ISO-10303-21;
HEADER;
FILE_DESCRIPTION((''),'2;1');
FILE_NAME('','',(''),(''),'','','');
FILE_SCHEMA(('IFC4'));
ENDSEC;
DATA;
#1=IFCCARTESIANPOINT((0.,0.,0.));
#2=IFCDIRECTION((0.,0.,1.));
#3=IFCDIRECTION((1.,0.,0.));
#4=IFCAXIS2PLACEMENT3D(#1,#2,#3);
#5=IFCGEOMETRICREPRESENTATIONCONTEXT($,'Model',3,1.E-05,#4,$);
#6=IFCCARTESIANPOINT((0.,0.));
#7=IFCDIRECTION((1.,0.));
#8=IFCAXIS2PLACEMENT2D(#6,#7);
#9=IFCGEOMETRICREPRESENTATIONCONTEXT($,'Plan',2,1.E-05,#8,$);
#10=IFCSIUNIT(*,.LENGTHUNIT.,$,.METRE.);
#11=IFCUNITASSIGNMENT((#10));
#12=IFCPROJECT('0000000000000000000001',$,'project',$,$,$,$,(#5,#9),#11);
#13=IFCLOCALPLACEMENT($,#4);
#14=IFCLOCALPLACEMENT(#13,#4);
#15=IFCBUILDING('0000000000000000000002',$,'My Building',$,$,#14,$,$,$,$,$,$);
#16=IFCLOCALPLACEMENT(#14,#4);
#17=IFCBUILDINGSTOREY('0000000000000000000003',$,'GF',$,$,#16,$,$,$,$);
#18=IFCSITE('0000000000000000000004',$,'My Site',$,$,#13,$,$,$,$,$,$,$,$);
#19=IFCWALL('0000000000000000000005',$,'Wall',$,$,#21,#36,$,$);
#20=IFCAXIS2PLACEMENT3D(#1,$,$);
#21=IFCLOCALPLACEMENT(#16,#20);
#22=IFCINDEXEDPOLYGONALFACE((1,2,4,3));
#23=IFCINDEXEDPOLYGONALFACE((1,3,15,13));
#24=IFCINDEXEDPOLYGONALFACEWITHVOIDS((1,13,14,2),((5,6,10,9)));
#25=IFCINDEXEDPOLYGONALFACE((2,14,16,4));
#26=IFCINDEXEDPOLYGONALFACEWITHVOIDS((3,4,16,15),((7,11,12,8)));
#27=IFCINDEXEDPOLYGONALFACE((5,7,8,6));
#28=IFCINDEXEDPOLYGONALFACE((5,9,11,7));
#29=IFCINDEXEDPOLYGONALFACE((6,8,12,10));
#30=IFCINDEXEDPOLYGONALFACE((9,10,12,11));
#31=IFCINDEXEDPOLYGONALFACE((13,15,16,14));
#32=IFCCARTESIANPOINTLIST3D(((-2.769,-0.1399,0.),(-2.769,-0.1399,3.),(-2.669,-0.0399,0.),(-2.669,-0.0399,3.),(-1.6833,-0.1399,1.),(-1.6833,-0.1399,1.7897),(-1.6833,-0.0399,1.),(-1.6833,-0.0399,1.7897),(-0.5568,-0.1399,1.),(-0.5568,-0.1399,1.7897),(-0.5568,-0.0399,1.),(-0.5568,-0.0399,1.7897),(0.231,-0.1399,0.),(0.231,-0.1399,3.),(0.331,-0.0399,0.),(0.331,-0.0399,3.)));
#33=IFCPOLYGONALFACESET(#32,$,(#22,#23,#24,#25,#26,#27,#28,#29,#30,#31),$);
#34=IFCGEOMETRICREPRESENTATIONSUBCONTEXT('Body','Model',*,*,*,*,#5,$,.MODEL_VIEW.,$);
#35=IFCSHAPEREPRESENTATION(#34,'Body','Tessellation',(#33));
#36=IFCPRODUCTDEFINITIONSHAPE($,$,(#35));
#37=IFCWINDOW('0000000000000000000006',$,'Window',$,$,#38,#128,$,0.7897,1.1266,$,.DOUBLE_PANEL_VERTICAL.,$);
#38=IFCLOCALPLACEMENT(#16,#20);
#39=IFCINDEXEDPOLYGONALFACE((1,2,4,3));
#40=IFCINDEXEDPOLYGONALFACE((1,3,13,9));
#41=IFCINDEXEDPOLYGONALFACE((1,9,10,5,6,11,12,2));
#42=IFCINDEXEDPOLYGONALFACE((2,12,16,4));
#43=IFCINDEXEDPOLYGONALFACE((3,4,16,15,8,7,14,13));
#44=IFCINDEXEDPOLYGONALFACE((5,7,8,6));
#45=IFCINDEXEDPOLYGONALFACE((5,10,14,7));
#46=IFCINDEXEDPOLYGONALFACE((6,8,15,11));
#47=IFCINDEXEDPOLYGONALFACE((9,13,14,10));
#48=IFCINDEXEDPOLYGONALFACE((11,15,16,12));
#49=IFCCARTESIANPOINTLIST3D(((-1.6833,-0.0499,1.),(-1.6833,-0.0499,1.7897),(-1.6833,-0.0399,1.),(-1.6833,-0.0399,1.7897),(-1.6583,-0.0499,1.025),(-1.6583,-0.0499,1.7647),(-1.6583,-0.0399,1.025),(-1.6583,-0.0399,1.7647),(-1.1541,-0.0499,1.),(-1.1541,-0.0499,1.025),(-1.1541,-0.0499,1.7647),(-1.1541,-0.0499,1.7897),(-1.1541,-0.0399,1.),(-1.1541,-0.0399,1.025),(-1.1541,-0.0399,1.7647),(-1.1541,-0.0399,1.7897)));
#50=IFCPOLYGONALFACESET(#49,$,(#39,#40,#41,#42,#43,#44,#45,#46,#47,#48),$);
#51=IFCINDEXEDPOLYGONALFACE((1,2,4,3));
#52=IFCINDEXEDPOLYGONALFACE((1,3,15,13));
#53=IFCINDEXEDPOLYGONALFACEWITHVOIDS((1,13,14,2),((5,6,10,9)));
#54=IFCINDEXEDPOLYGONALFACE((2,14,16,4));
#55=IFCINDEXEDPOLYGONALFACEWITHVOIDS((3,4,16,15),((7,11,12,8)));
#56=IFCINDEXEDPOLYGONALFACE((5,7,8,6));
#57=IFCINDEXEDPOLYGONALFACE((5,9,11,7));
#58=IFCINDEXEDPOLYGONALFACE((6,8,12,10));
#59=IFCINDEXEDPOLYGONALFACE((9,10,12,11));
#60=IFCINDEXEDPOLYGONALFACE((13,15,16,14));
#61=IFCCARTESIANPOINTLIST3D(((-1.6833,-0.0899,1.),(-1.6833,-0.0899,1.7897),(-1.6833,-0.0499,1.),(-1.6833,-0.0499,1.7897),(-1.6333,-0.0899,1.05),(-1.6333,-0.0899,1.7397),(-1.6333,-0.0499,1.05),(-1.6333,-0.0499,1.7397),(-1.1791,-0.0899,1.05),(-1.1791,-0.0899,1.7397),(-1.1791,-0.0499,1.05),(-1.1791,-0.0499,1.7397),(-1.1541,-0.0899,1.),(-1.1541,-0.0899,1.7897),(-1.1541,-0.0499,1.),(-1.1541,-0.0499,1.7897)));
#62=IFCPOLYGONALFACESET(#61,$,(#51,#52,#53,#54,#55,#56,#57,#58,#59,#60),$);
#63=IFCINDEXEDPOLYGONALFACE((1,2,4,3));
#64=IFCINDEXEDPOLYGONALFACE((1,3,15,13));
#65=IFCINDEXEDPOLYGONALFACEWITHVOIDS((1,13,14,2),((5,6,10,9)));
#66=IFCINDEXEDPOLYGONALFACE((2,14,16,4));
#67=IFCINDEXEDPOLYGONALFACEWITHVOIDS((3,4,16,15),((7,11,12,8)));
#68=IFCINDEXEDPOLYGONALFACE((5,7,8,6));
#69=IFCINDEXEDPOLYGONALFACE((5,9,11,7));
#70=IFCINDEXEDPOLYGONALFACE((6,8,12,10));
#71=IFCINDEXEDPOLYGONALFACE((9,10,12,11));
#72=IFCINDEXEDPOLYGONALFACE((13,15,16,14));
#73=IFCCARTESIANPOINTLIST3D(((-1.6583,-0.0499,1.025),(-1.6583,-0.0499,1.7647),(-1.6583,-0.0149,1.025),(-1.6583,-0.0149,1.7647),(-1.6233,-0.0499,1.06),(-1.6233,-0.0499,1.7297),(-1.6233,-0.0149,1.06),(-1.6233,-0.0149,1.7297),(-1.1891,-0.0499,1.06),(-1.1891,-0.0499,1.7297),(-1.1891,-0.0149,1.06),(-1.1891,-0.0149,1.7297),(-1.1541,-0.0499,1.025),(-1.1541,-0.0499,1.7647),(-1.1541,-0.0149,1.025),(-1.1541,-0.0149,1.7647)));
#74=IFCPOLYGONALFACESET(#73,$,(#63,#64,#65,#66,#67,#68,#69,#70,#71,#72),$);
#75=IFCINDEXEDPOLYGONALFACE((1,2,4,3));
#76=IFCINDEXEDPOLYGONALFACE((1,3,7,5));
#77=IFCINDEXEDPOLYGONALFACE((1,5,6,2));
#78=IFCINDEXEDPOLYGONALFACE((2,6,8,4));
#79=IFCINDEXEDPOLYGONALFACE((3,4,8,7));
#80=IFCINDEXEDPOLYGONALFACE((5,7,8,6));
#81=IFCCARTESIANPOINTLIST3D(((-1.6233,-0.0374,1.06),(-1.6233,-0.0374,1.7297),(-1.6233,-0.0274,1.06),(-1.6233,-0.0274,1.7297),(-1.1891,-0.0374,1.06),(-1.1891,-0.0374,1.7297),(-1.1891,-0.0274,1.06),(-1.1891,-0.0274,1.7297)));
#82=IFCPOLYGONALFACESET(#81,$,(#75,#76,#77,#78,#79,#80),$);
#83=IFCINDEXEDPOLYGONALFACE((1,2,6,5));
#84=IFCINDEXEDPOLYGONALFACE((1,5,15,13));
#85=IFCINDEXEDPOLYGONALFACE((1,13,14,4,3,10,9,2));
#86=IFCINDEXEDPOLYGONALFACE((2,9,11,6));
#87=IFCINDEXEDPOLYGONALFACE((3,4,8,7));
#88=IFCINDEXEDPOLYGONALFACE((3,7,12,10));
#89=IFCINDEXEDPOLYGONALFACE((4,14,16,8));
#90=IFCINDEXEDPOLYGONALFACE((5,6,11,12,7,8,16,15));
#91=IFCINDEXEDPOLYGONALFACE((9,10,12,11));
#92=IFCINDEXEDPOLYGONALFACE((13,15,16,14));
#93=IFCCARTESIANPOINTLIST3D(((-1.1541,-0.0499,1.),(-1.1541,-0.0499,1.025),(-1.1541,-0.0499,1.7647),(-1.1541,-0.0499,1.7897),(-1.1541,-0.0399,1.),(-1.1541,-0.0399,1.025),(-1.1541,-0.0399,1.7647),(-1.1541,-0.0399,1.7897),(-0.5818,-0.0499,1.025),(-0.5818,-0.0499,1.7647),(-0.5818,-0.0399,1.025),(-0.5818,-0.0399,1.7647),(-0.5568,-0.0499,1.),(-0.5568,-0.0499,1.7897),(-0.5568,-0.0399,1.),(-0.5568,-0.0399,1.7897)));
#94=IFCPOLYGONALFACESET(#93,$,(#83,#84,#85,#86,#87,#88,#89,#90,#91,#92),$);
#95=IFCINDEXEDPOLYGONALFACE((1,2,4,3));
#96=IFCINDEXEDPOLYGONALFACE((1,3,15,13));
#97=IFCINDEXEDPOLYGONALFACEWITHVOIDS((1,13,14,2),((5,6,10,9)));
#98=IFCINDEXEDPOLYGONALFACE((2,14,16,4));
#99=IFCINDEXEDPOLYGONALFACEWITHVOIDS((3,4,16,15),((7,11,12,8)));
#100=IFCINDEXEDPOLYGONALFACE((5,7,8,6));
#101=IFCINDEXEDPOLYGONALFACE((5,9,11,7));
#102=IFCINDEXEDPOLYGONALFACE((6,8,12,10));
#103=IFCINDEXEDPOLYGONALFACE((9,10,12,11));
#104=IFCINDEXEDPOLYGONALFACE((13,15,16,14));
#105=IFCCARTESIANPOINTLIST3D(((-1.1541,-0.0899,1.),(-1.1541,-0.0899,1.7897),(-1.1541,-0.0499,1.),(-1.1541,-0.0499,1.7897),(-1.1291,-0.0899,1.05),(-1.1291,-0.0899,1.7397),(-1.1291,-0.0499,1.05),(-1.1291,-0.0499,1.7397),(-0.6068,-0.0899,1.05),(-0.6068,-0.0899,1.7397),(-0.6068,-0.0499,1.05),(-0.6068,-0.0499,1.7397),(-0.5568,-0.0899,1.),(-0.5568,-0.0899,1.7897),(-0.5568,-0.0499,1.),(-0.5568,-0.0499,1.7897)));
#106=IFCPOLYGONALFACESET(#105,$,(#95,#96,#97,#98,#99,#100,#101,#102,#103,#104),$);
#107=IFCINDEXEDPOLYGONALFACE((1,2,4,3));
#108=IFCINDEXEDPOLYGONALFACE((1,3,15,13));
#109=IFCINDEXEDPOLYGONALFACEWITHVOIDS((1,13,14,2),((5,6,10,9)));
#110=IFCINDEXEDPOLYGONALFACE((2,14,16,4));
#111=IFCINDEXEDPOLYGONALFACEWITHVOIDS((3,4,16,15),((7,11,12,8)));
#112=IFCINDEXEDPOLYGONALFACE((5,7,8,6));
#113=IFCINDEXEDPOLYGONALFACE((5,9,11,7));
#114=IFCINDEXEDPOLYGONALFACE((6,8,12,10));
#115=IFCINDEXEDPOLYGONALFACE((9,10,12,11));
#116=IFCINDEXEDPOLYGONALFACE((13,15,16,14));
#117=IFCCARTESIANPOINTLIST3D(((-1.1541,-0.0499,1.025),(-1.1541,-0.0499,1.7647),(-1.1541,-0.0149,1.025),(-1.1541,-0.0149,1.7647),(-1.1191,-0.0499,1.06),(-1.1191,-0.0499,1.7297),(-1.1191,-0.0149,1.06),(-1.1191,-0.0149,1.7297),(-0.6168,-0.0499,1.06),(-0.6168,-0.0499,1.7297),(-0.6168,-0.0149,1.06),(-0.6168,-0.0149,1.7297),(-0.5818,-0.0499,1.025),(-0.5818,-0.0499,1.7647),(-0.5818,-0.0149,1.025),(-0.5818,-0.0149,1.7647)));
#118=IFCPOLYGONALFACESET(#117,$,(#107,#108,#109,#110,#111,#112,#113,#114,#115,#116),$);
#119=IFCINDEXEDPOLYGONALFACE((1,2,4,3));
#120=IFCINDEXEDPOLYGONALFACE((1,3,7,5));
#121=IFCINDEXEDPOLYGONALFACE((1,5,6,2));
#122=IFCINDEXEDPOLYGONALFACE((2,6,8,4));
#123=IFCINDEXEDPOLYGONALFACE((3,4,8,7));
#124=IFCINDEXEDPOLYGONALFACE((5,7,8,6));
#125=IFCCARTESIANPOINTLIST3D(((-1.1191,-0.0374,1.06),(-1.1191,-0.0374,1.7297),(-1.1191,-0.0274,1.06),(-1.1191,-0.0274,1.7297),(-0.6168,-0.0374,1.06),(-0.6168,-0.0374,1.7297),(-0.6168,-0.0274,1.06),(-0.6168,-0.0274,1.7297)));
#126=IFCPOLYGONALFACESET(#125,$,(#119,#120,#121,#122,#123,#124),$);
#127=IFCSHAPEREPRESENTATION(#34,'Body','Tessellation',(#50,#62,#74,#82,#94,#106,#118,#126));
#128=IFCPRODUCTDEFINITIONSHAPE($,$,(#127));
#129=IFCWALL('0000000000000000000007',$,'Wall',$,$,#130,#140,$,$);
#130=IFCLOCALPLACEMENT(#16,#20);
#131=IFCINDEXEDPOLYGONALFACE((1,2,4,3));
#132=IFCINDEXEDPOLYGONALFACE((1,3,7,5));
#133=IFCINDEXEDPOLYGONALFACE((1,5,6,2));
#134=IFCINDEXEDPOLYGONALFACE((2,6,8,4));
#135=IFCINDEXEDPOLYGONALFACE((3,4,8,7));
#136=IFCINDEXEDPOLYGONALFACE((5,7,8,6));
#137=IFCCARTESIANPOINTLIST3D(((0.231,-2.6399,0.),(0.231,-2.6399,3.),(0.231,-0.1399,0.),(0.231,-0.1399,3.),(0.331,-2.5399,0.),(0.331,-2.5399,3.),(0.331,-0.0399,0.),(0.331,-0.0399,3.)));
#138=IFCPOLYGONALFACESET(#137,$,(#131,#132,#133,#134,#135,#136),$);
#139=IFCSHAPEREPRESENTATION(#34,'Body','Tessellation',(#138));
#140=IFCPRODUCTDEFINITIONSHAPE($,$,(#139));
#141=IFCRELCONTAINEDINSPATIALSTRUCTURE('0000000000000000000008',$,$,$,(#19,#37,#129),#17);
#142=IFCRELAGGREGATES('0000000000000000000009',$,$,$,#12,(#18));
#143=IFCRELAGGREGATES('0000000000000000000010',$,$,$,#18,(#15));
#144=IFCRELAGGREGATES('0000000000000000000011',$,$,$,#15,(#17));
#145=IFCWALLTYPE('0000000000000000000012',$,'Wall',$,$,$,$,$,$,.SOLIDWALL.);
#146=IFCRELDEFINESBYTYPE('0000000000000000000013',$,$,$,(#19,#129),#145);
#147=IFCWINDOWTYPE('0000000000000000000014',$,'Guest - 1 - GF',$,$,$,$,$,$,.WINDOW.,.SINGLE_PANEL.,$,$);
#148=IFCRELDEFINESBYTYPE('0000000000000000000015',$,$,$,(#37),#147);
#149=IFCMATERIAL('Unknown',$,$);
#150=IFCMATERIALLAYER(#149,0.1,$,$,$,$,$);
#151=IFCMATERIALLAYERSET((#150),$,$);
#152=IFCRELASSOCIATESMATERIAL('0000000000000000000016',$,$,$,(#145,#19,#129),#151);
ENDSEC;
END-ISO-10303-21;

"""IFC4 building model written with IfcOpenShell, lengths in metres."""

from ifc_helpers import new_model, entity, si_unit, frame, origin_with_axes, origin_2d_with_axis, place, context, subcontext, project, spatial, line, indexed_curve, outline, extrude, shape, source, transform, mapped, material, layer, layer_set, layer_usage, type_object, type_shapes, element, fill, save


model = new_model("IFC4")

# Units and contexts
model_context = context("Model", 3, precision=1e-05, world=origin_with_axes())
plan_context = context("Plan", 2, precision=1e-05, world=origin_2d_with_axis())
body_context_1 = subcontext(model_context, "Body", "Model", "MODEL_VIEW")
body_context_2 = subcontext(plan_context, "Body", "Plan", "PLAN_VIEW")
ifc_project = project(units=[si_unit("LENGTHUNIT", "METRE")], contexts=[model_context, plan_context])

# Site, building, storey
site_placement = place(None, origin_with_axes())
site = spatial("IfcSite", under=ifc_project, at=site_placement, Name="My Site")
building_placement = place(site_placement, origin_with_axes())
building = spatial("IfcBuilding", under=site, at=building_placement, Name="My Building")
storey_placement = place(building_placement, origin_with_axes())
storey = spatial("IfcBuildingStorey", under=building, at=storey_placement, Name="GF")

# Shared definitions
ifc_material = material(Name="Unknown")

# Shared definitions
ifc_layer_1 = layer(ifc_material, 0.1)
ifc_layer_set_1 = layer_set([ifc_layer_1])
wall_type = type_object("IfcWallType", Name="Wall", PredefinedType="SOLIDWALL", material=ifc_layer_set_1)

# Wall, opening, window
ifc_layer_usage_1 = layer_usage(ifc_layer_set_1, "AXIS2", "POSITIVE", 0.0)
wall_1_placement = place(storey_placement, frame((-2.769, -0.1399, 0.0), z_axis=(0.0, 0.0, 1.0), x_axis=(1.0, 0.0, 0.0)))
wall_1 = element("IfcWall", 1, at=wall_1_placement, inside=storey, type_object=wall_type, material=ifc_layer_usage_1, Name="Wall", context=body_context_1, shape_type="SweptSolid", body=[
    extrude(outline(indexed_curve([(0.0, 0.0), (0.1, 0.1), (3.1, 0.1), (3.0, 0.0)], segments=[line(1, 2, 3, 4, 1)])), origin_with_axes(), (0.0, 0.0, 1.0), 3.0),
])
shared_shape_1 = source(origin_with_axes(), body_context_1, "Body", "SweptSolid", [
    extrude(outline(indexed_curve([(0.0, 0.0), (1.1266, 0.0), (1.1266, 0.7897), (0.0, 0.7897)], segments=[line(1, 2, 3, 4, 1)])), frame((0.0, -0.6, 0.0), z_axis=(0.0, -1.0, 0.0), x_axis=(1.0, 0.0, 0.0)), (0.0, 0.0, -1.0), 1.2),
])
opening_1_placement = place(wall_1_placement, frame((1.0857, 0.0, 1.0), z_axis=(0.0, 0.0, 1.0), x_axis=(1.0, 0.0, 0.0)))
opening_1 = element("IfcOpeningElement", 2, at=opening_1_placement, cuts=wall_1, PredefinedType="OPENING", context=body_context_1, shape_type="MappedRepresentation", body=[
    mapped(shared_shape_1, transform((0.0, 0.0, 0.0), x_axis=(1.0, 0.0, 0.0), y_axis=(0.0, 1.0, 0.0), z_axis=(0.0, 0.0, 1.0), scale=1.0)),
])
window_type_1 = type_object("IfcWindowType", Name="Guest - 1 - GF", PartitioningType="SINGLE_PANEL", PredefinedType="WINDOW")
shared_shape_2 = source(origin_with_axes(), body_context_1, "Body", "SweptSolid", [
    extrude(outline(indexed_curve([(0.5292, 0.0), (0.0, 0.0), (0.0, 0.7897), (0.5292, 0.7897), (0.5292, 0.7647), (0.025, 0.7647), (0.025, 0.025), (0.5292, 0.025)], segments=[line(1, 2, 3, 4, 5, 6, 7, 8, 1)])), frame((0.0, 0.09, 0.0), z_axis=(0.0, -1.0, 0.0), x_axis=(1.0, 0.0, 0.0)), (0.0, 0.0, -1.0), 0.01),
    extrude(outline(indexed_curve([(0.0, 0.0), (0.5292, 0.0), (0.5292, 0.7897), (0.0, 0.7897)], segments=[line(1, 2, 3, 4, 1)]), holes=[indexed_curve([(0.05, 0.05), (0.5042, 0.05), (0.5042, 0.7397), (0.05, 0.7397)], segments=[line(1, 2, 3, 4, 1)])]), frame((0.0, 0.05, 0.0), z_axis=(0.0, -1.0, 0.0), x_axis=(1.0, 0.0, 0.0)), (0.0, 0.0, -1.0), 0.04),
    extrude(outline(indexed_curve([(0.0, 0.0), (0.5042, 0.0), (0.5042, 0.7397), (0.0, 0.7397)], segments=[line(1, 2, 3, 4, 1)]), holes=[indexed_curve([(0.035, 0.035), (0.4692, 0.035), (0.4692, 0.7047), (0.035, 0.7047)], segments=[line(1, 2, 3, 4, 1)])]), frame((0.025, 0.09, 0.025), z_axis=(0.0, -1.0, 0.0), x_axis=(1.0, 0.0, 0.0)), (0.0, 0.0, -1.0), 0.035),
    extrude(outline(indexed_curve([(0.035, 0.035), (0.4692, 0.035), (0.4692, 0.7047), (0.035, 0.7047)], segments=[line(1, 2, 3, 4, 1)])), frame((0.025, 0.1025, 0.025), z_axis=(0.0, -1.0, 0.0), x_axis=(1.0, 0.0, 0.0)), (0.0, 0.0, -1.0), 0.01),
    extrude(outline(indexed_curve([(0.0, 0.7897), (0.5973, 0.7897), (0.5973, 0.0), (0.0, 0.0), (0.0, 0.025), (0.5723, 0.025), (0.5723, 0.7647), (0.0, 0.7647)], segments=[line(1, 2, 3, 4, 5, 6, 7, 8, 1)])), frame((0.5292, 0.09, 0.0), z_axis=(0.0, -1.0, 0.0), x_axis=(1.0, 0.0, 0.0)), (0.0, 0.0, -1.0), 0.01),
    extrude(outline(indexed_curve([(0.0, 0.0), (0.5973, 0.0), (0.5973, 0.7897), (0.0, 0.7897)], segments=[line(1, 2, 3, 4, 1)]), holes=[indexed_curve([(0.025, 0.05), (0.5473, 0.05), (0.5473, 0.7397), (0.025, 0.7397)], segments=[line(1, 2, 3, 4, 1)])]), frame((0.5292, 0.05, 0.0), z_axis=(0.0, -1.0, 0.0), x_axis=(1.0, 0.0, 0.0)), (0.0, 0.0, -1.0), 0.04),
    extrude(outline(indexed_curve([(0.0, 0.0), (0.5723, 0.0), (0.5723, 0.7397), (0.0, 0.7397)], segments=[line(1, 2, 3, 4, 1)]), holes=[indexed_curve([(0.035, 0.035), (0.5373, 0.035), (0.5373, 0.7047), (0.035, 0.7047)], segments=[line(1, 2, 3, 4, 1)])]), frame((0.5292, 0.09, 0.025), z_axis=(0.0, -1.0, 0.0), x_axis=(1.0, 0.0, 0.0)), (0.0, 0.0, -1.0), 0.035),
    extrude(outline(indexed_curve([(0.035, 0.035), (0.5373, 0.035), (0.5373, 0.7047), (0.035, 0.7047)], segments=[line(1, 2, 3, 4, 1)])), frame((0.5292, 0.1025, 0.025), z_axis=(0.0, -1.0, 0.0), x_axis=(1.0, 0.0, 0.0)), (0.0, 0.0, -1.0), 0.01),
])
shared_shape_3 = source(origin_with_axes(), body_context_2, "Body", "Curve2D", [
    entity("IfcIndexedPolyCurve", entity("IfcCartesianPointList2D", [[0.05, 0.05], [0.5042, 0.05]])),
    entity("IfcIndexedPolyCurve", entity("IfcCartesianPointList2D", [[0.0, 0.1], [0.025, 0.1], [0.025, 0.09], [0.05, 0.09], [0.05, 0.05], [0.0, 0.05]]), [entity("IfcLineIndex", [1, 2, 3, 4, 5, 6, 1])]),
    entity("IfcIndexedPolyCurve", entity("IfcCartesianPointList2D", [[0.5292, 0.1], [0.5292, 0.1], [0.5292, 0.09], [0.5042, 0.09], [0.5042, 0.05], [0.5292, 0.05]])),
    entity("IfcIndexedPolyCurve", entity("IfcCartesianPointList2D", [[0.025, 0.09], [0.06, 0.09], [0.06, 0.125], [0.025, 0.125]]), [entity("IfcLineIndex", [1, 2, 3, 4, 1])]),
    entity("IfcIndexedPolyCurve", entity("IfcCartesianPointList2D", [[0.5292, 0.09], [0.4942, 0.09], [0.4942, 0.125], [0.5292, 0.125]]), [entity("IfcLineIndex", [1, 2, 3, 4, 1])]),
    entity("IfcIndexedPolyCurve", entity("IfcCartesianPointList2D", [[0.06, 0.09], [0.4942, 0.09]])),
    entity("IfcIndexedPolyCurve", entity("IfcCartesianPointList2D", [[0.06, 0.125], [0.4942, 0.125]])),
    entity("IfcIndexedPolyCurve", entity("IfcCartesianPointList2D", [[0.06, 0.1075], [0.4942, 0.1075]])),
    entity("IfcIndexedPolyCurve", entity("IfcCartesianPointList2D", [[0.5542, 0.05], [1.0766, 0.05]])),
    entity("IfcIndexedPolyCurve", entity("IfcCartesianPointList2D", [[0.5292, 0.1], [0.5292, 0.1], [0.5292, 0.09], [0.5542, 0.09], [0.5542, 0.05], [0.5292, 0.05]])),
    entity("IfcIndexedPolyCurve", entity("IfcCartesianPointList2D", [[1.1266, 0.1], [1.1016, 0.1], [1.1016, 0.09], [1.0766, 0.09], [1.0766, 0.05], [1.1266, 0.05]]), [entity("IfcLineIndex", [1, 2, 3, 4, 5, 6, 1])]),
    entity("IfcIndexedPolyCurve", entity("IfcCartesianPointList2D", [[0.5292, 0.09], [0.5642, 0.09], [0.5642, 0.125], [0.5292, 0.125]]), [entity("IfcLineIndex", [1, 2, 3, 4, 1])]),
    entity("IfcIndexedPolyCurve", entity("IfcCartesianPointList2D", [[1.1016, 0.09], [1.0666, 0.09], [1.0666, 0.125], [1.1016, 0.125]]), [entity("IfcLineIndex", [1, 2, 3, 4, 1])]),
    entity("IfcIndexedPolyCurve", entity("IfcCartesianPointList2D", [[0.5642, 0.09], [1.0666, 0.09]])),
    entity("IfcIndexedPolyCurve", entity("IfcCartesianPointList2D", [[0.5642, 0.125], [1.0666, 0.125]])),
    entity("IfcIndexedPolyCurve", entity("IfcCartesianPointList2D", [[0.5642, 0.1075], [1.0666, 0.1075]])),
])
type_shapes(window_type_1, [shared_shape_2, shared_shape_3])
window_1_placement = place(opening_1_placement, origin_with_axes())
window_1 = element("IfcWindow", 3, at=window_1_placement, inside=storey, type_object=window_type_1, Name="Window", OverallHeight=0.7897, OverallWidth=1.1266, PartitioningType="DOUBLE_PANEL_VERTICAL", shapes=[
    shape(body_context_1, "Body", "MappedRepresentation", [mapped(shared_shape_2, transform((0.0, 0.0, 0.0), x_axis=(1.0, 0.0, 0.0), y_axis=(0.0, 1.0, 0.0), z_axis=(0.0, 0.0, 1.0), scale=1.0))]),
    shape(body_context_2, "Body", "MappedRepresentation", [mapped(shared_shape_3, transform((0.0, 0.0, 0.0), x_axis=(1.0, 0.0, 0.0), y_axis=(0.0, 1.0, 0.0), z_axis=(0.0, 0.0, 1.0), scale=1.0))]),
])
fill(opening_1, window_1)

# Wall
ifc_layer_usage_2 = layer_usage(ifc_layer_set_1, "AXIS2", "POSITIVE", 0.0)
wall_2_placement = place(storey_placement, frame((0.231, -0.1399, 0.0), z_axis=(0.0, 0.0, 1.0), x_axis=(0.0, -1.0, 0.0)))
element("IfcWall", 4, at=wall_2_placement, inside=storey, type_object=wall_type, material=ifc_layer_usage_2, Name="Wall", context=body_context_1, shape_type="SweptSolid", body=[
    extrude(outline(indexed_curve([(0.0, 0.0), (-0.1, 0.1), (2.4, 0.1), (2.5, 0.0)], segments=[line(1, 2, 3, 4, 1)])), origin_with_axes(), (0.0, 0.0, 1.0), 3.0),
])

save(model, "model.ifc")
